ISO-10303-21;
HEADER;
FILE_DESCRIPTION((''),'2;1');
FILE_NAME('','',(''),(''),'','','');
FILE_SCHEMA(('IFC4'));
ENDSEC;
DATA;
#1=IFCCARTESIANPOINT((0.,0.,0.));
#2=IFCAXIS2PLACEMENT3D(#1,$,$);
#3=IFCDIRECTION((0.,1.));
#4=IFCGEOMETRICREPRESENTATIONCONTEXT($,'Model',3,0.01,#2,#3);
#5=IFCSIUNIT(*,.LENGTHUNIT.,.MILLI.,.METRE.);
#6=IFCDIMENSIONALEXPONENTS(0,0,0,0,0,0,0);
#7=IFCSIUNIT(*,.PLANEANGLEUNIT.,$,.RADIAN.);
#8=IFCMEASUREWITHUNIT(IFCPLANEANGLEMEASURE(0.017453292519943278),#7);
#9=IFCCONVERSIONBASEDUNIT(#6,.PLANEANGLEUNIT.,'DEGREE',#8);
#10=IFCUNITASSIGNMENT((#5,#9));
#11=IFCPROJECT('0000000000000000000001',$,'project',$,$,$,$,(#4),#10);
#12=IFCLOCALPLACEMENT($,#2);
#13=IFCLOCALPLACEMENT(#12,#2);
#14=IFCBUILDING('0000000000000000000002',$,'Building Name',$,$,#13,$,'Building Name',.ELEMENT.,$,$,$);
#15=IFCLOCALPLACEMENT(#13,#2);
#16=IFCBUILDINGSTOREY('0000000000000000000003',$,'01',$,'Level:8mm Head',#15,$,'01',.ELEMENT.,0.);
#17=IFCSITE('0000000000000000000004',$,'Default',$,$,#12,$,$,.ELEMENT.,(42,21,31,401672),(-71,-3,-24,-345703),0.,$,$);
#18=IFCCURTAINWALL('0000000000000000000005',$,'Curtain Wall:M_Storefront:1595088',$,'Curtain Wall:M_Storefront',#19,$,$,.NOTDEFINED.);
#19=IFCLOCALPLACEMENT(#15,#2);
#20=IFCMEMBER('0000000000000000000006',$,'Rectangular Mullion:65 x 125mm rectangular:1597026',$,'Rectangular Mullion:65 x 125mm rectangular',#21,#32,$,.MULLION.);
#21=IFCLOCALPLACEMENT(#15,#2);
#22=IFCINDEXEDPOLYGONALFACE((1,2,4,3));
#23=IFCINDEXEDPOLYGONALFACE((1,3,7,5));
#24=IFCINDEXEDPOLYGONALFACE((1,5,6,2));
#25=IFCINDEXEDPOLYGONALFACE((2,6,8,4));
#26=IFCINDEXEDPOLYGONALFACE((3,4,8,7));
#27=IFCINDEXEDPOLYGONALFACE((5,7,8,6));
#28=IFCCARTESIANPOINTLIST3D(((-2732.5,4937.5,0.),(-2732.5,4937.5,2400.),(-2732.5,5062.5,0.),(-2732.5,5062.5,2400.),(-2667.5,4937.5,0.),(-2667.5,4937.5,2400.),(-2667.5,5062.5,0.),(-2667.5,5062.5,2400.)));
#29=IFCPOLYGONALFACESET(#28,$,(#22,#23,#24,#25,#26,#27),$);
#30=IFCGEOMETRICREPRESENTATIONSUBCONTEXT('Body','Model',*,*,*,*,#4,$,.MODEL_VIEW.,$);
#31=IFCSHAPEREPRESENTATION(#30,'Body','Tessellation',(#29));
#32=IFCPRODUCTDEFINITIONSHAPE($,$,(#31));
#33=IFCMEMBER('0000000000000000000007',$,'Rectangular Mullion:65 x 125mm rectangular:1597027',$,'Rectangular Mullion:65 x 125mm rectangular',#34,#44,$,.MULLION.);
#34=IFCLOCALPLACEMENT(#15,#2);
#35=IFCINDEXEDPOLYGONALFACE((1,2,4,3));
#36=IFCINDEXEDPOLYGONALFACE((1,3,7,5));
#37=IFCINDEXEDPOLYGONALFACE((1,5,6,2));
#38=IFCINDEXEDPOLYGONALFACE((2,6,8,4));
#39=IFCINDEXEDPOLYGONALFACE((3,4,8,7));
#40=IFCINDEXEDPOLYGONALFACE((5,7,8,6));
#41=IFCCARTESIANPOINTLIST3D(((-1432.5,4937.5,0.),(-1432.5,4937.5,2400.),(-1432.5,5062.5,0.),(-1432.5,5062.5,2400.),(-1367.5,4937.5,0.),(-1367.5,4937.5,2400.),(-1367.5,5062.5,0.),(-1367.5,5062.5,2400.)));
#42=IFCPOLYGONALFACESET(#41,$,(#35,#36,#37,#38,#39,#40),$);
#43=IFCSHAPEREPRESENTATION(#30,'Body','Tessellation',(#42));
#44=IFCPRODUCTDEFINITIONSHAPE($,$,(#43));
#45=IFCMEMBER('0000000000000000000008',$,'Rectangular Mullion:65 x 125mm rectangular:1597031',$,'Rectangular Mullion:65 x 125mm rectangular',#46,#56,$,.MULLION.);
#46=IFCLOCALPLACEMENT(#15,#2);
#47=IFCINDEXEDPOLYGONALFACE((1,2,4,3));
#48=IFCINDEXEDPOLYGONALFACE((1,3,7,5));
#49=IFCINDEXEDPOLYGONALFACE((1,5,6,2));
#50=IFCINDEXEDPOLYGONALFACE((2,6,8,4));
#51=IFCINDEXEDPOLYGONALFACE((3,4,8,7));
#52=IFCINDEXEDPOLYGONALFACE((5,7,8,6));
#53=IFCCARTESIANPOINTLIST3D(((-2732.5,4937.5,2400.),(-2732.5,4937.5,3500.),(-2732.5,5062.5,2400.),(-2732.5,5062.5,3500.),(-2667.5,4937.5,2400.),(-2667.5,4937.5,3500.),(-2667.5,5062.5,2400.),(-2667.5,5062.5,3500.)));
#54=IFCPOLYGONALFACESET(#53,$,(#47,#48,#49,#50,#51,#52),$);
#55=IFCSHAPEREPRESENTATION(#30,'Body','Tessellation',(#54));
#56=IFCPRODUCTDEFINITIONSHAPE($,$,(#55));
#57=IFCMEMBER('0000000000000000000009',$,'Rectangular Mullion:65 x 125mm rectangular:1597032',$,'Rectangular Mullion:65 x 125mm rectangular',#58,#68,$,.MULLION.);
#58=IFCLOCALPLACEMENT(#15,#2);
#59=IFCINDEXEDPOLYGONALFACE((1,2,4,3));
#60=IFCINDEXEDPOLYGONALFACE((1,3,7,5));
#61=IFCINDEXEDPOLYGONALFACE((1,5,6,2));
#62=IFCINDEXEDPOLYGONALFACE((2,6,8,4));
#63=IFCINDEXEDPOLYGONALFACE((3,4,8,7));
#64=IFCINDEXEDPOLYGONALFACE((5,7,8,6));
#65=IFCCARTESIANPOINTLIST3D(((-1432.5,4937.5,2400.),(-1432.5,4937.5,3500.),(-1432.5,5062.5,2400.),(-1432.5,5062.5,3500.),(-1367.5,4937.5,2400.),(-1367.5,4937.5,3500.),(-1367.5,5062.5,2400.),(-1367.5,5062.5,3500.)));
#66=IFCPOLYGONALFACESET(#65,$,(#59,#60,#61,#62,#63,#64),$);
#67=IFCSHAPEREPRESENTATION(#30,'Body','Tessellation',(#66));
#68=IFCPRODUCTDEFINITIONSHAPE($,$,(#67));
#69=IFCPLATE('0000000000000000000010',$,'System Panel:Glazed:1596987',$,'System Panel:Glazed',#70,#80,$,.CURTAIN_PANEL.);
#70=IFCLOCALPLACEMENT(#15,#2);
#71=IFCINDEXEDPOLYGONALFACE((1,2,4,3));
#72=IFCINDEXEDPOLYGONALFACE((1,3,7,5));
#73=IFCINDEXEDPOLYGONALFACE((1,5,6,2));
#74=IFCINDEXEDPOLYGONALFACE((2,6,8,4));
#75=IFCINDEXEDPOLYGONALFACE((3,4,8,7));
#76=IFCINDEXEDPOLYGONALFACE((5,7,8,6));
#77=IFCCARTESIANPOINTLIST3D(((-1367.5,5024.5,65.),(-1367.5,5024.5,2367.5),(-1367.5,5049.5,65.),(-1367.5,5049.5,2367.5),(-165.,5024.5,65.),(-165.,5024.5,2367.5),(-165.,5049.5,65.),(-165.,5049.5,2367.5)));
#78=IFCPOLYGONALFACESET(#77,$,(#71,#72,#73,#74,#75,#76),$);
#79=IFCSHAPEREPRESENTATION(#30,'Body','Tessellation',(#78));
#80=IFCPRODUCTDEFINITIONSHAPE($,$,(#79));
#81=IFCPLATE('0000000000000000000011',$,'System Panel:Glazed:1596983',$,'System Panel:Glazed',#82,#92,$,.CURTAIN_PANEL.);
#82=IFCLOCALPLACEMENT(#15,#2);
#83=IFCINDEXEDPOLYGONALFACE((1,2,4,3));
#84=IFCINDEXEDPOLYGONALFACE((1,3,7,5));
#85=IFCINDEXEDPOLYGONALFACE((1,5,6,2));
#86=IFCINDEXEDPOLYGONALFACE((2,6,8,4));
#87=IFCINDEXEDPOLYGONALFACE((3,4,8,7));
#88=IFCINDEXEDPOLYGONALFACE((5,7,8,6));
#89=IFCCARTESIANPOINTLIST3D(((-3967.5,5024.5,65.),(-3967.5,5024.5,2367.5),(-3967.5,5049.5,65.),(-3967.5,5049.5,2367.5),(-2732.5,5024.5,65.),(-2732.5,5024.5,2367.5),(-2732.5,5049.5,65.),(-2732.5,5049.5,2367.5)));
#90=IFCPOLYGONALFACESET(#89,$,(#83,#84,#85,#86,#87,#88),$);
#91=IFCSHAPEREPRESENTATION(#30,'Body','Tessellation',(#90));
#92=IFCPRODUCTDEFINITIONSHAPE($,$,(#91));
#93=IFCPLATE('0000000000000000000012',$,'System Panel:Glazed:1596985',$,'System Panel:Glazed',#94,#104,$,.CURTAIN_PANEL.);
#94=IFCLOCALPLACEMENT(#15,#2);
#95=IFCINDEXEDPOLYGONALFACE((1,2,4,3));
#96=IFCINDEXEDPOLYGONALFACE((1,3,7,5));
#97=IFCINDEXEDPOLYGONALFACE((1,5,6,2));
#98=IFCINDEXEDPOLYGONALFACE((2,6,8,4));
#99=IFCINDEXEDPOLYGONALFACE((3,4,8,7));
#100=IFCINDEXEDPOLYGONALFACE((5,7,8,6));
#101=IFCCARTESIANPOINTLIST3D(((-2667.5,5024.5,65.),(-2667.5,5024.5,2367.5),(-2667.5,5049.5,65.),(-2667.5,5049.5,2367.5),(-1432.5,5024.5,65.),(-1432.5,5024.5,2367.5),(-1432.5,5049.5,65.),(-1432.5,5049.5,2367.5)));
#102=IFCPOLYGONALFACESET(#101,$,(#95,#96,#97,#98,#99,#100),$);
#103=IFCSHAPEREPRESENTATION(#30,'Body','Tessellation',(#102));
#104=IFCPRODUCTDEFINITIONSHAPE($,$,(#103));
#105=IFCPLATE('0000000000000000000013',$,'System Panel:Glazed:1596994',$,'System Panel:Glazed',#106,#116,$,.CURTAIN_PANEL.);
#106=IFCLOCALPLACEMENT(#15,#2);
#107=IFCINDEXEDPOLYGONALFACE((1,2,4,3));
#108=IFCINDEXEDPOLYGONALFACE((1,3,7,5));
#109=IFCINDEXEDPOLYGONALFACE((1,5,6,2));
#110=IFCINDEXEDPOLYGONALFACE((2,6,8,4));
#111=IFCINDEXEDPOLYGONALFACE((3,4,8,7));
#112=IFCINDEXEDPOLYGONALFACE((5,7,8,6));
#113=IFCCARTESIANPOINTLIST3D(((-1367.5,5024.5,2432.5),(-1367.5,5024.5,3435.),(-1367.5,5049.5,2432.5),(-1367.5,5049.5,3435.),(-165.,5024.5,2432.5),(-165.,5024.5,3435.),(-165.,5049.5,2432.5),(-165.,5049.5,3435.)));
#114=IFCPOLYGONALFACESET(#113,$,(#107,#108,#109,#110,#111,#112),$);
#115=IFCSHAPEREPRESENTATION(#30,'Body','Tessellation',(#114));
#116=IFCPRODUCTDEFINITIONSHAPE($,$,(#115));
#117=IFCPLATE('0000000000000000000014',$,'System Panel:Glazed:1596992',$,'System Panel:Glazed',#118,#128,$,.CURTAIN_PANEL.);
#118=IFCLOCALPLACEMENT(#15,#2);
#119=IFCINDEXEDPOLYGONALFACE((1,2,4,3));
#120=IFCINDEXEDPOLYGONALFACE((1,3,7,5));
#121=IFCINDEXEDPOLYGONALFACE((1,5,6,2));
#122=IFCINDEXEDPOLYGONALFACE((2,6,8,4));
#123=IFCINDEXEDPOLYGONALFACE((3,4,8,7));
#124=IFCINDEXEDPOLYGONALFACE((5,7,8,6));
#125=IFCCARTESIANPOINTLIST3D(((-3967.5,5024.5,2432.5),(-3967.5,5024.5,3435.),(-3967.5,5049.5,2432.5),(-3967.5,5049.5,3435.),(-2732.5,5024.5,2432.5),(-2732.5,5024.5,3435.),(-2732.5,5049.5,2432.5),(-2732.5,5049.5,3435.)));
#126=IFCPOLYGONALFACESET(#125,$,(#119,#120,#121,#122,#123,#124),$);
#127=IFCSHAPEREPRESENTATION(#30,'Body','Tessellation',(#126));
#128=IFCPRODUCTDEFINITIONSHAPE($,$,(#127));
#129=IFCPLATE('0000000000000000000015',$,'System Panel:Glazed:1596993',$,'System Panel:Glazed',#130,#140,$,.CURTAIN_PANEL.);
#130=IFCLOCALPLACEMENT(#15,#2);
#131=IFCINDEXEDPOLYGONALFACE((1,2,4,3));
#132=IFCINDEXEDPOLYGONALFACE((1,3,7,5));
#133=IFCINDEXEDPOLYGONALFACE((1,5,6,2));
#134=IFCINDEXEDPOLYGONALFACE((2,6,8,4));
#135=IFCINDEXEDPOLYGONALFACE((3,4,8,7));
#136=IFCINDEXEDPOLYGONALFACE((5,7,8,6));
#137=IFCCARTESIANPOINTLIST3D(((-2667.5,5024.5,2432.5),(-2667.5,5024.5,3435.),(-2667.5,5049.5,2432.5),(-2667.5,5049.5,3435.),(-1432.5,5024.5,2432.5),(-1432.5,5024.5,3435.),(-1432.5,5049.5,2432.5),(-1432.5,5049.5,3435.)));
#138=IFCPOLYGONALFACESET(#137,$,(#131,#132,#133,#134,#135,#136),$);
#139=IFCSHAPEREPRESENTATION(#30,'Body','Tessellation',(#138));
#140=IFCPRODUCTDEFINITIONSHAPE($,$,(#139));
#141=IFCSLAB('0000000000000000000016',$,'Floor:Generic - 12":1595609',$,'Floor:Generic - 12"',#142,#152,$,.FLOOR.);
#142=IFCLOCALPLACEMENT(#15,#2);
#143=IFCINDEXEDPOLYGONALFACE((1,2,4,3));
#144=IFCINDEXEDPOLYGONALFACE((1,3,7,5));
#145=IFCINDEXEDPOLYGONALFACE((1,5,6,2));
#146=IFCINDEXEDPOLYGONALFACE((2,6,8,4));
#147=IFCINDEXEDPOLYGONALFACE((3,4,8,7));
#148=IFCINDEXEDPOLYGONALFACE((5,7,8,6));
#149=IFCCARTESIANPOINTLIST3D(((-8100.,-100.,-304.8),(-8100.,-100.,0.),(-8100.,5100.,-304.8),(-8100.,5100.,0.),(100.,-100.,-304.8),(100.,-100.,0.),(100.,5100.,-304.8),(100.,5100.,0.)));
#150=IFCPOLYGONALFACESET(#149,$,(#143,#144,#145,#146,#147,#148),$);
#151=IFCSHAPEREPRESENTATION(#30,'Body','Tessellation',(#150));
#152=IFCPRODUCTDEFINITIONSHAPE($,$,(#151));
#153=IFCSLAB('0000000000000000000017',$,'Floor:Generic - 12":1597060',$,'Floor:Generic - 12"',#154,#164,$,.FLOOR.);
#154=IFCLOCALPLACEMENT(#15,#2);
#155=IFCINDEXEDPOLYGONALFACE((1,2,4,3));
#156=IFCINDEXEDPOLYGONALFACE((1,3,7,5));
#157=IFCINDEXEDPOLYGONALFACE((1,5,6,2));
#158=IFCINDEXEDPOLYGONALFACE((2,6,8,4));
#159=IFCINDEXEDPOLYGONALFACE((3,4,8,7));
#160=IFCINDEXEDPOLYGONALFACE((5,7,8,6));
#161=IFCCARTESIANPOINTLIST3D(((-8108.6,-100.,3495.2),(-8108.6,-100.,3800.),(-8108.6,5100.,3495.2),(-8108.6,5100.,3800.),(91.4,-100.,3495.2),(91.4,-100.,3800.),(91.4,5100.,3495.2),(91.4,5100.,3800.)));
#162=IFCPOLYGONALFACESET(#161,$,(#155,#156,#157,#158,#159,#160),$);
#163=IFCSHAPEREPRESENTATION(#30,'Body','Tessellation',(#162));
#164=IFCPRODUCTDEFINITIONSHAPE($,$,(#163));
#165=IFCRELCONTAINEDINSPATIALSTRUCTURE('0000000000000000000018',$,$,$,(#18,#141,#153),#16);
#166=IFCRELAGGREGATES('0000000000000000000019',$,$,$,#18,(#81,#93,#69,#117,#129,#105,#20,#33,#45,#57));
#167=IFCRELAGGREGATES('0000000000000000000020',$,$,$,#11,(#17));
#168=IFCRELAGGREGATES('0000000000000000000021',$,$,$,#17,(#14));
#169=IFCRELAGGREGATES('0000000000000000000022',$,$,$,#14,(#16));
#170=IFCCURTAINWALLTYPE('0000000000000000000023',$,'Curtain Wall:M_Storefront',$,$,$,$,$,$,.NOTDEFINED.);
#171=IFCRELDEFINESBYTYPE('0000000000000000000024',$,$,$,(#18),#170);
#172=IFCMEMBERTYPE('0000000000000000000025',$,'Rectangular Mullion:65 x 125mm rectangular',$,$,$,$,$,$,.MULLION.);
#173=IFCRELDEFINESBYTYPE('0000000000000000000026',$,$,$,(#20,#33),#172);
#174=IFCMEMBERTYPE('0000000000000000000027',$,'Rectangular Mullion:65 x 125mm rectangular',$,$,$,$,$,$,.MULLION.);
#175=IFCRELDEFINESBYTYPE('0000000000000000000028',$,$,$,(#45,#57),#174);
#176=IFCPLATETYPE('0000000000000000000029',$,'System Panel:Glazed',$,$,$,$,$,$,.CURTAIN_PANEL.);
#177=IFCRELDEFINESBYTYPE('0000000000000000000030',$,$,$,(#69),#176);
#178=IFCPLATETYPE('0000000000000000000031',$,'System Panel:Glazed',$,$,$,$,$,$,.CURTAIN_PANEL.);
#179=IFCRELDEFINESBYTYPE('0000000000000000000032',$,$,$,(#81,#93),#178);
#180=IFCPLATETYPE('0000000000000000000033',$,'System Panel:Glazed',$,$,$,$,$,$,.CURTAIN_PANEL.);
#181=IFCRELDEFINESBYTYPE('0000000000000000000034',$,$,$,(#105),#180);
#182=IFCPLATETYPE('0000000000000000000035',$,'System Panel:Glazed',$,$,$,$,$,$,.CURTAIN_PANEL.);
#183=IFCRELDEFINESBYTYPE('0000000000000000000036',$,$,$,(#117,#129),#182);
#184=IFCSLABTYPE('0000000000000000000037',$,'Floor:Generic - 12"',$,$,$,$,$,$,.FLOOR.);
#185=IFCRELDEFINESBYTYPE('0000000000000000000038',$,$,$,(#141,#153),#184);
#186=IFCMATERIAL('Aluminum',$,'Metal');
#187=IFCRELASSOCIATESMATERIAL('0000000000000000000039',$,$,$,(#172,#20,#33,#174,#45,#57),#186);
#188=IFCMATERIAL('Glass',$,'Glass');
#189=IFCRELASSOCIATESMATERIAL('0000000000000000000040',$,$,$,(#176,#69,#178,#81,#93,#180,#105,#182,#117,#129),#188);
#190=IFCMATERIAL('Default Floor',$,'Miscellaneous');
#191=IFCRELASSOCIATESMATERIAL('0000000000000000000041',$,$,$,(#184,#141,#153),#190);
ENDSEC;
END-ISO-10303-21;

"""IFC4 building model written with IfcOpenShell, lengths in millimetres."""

from ifc_helpers import new_model, entity, si_unit, converted_unit, direction, frame, origin, place, context, subcontext, project, spatial, indexed_curve, outline, extrude, source, transform, mapped, material, type_object, type_shapes, element, aggregate, save


model = new_model("IFC4")

# Units and contexts
model_context = context("Model", 3, precision=0.01, world=origin(), true_north=direction((0.0, 1.0)))
body_context = subcontext(model_context, "Body", "Model", "MODEL_VIEW")
ifc_project = project(units=[si_unit("LENGTHUNIT", "METRE", prefix="MILLI"), converted_unit("PLANEANGLEUNIT", "DEGREE", entity("IfcPlaneAngleMeasure", 0.017453292519943278), si_unit("PLANEANGLEUNIT", "RADIAN"), dimensions=[0, 0, 0, 0, 0, 0, 0])], contexts=[model_context])

# Site, building, storey
site_placement = place(None, origin())
site = spatial("IfcSite", under=ifc_project, at=site_placement, Name="Default", CompositionType="ELEMENT", RefLatitude=(42, 21, 31, 401672), RefLongitude=(-71, -3, -24, -345703), RefElevation=0.0)
building_placement = place(site_placement, origin())
building = spatial("IfcBuilding", under=site, at=building_placement, Name="Building Name", LongName="Building Name", CompositionType="ELEMENT")
storey_placement = place(building_placement, origin())
storey = spatial("IfcBuildingStorey", under=building, at=storey_placement, Name="01", ObjectType="Level:8mm Head", LongName="01", CompositionType="ELEMENT", Elevation=0.0)

# Curtain wall, members, plates
curtain_wall_type = type_object("IfcCurtainWallType", Name="Curtain Wall:M_Storefront", PredefinedType="NOTDEFINED")
curtain_wall_placement = place(storey_placement, origin())
curtain_wall = element("IfcCurtainWall", 1, at=curtain_wall_placement, inside=storey, type_object=curtain_wall_type, Name="Curtain Wall:M_Storefront:1595088", ObjectType="Curtain Wall:M_Storefront", PredefinedType="NOTDEFINED")
ifc_material_1 = material(Name="Aluminum", Category="Metal")
member_type_1 = type_object("IfcMemberType", Name="Rectangular Mullion:65 x 125mm rectangular", PredefinedType="MULLION", material=ifc_material_1)
shared_shape_1 = source(origin(), body_context, "Body", "SweptSolid", [
    extrude(outline(indexed_curve([(-32.5, -62.5), (32.5, -62.5), (32.5, 62.5), (-32.5, 62.5), (-32.5, -62.5)], self_intersect=False)), frame((0.0, 0.0, -2400.0), z_axis=(0.0, 0.0, 1.0), x_axis=(-1.0, 0.0, 0.0)), (0.0, 0.0, 1.0), 2400.0),
])
type_shapes(member_type_1, [shared_shape_1])
member_1_placement = place(curtain_wall_placement, frame((-2700.0, 5000.0, 0.0), z_axis=(0.0, 0.0, -1.0), x_axis=(1.0, 0.0, 0.0)))
member_1 = element("IfcMember", 2, at=member_1_placement, type_object=member_type_1, material=ifc_material_1, Name="Rectangular Mullion:65 x 125mm rectangular:1597026", ObjectType="Rectangular Mullion:65 x 125mm rectangular", PredefinedType="MULLION", context=body_context, shape_type="MappedRepresentation", body=[
    mapped(shared_shape_1, transform((0.0, 0.0, 0.0), scale=1.0)),
])
member_2_placement = place(curtain_wall_placement, frame((-1400.0, 5000.0, 0.0), z_axis=(0.0, 0.0, -1.0), x_axis=(1.0, 0.0, 0.0)))
member_2 = element("IfcMember", 3, at=member_2_placement, type_object=member_type_1, material=ifc_material_1, Name="Rectangular Mullion:65 x 125mm rectangular:1597027", ObjectType="Rectangular Mullion:65 x 125mm rectangular", PredefinedType="MULLION", context=body_context, shape_type="MappedRepresentation", body=[
    mapped(shared_shape_1, transform((0.0, 0.0, 0.0), scale=1.0)),
])
member_type_2 = type_object("IfcMemberType", Name="Rectangular Mullion:65 x 125mm rectangular", PredefinedType="MULLION", material=ifc_material_1)
shared_shape_2 = source(origin(), body_context, "Body", "SweptSolid", [
    extrude(outline(indexed_curve([(-32.5, -62.5), (32.5, -62.5), (32.5, 62.5), (-32.5, 62.5), (-32.5, -62.5)], self_intersect=False)), frame((0.0, 0.0, -1100.0), z_axis=(0.0, 0.0, 1.0), x_axis=(-1.0, 0.0, 0.0)), (0.0, 0.0, 1.0), 1100.0),
])
type_shapes(member_type_2, [shared_shape_2])
member_3_placement = place(curtain_wall_placement, frame((-2700.0, 5000.0, 2400.0), z_axis=(0.0, 0.0, -1.0), x_axis=(1.0, 0.0, 0.0)))
member_3 = element("IfcMember", 4, at=member_3_placement, type_object=member_type_2, material=ifc_material_1, Name="Rectangular Mullion:65 x 125mm rectangular:1597031", ObjectType="Rectangular Mullion:65 x 125mm rectangular", PredefinedType="MULLION", context=body_context, shape_type="MappedRepresentation", body=[
    mapped(shared_shape_2, transform((0.0, 0.0, 0.0), scale=1.0)),
])
member_4_placement = place(curtain_wall_placement, frame((-1400.0, 5000.0, 2400.0), z_axis=(0.0, 0.0, -1.0), x_axis=(1.0, 0.0, 0.0)))
member_4 = element("IfcMember", 5, at=member_4_placement, type_object=member_type_2, material=ifc_material_1, Name="Rectangular Mullion:65 x 125mm rectangular:1597032", ObjectType="Rectangular Mullion:65 x 125mm rectangular", PredefinedType="MULLION", context=body_context, shape_type="MappedRepresentation", body=[
    mapped(shared_shape_2, transform((0.0, 0.0, 0.0), scale=1.0)),
])
ifc_material_2 = material(Name="Glass", Category="Glass")
plate_type_1 = type_object("IfcPlateType", Name="System Panel:Glazed", PredefinedType="CURTAIN_PANEL", material=ifc_material_2)
shared_shape_3 = source(origin(), body_context, "Body", "SweptSolid", [
    extrude(outline(indexed_curve([(-12.5, -601.3), (12.5, -601.3), (12.5, 601.3), (-12.5, 601.3), (-12.5, -601.3)], self_intersect=False)), frame((0.0, 37.0, 0.0), z_axis=(0.0, 0.0, 1.0), x_axis=(0.0, 1.0, 0.0)), (0.0, 0.0, 1.0), 2302.5),
])
type_shapes(plate_type_1, [shared_shape_3])
plate_1_placement = place(curtain_wall_placement, frame((-766.3, 5000.0, 65.0)))
plate_1 = element("IfcPlate", 6, at=plate_1_placement, type_object=plate_type_1, material=ifc_material_2, Name="System Panel:Glazed:1596987", ObjectType="System Panel:Glazed", PredefinedType="CURTAIN_PANEL", context=body_context, shape_type="MappedRepresentation", body=[
    mapped(shared_shape_3, transform((0.0, 0.0, 0.0), scale=1.0)),
])
plate_type_2 = type_object("IfcPlateType", Name="System Panel:Glazed", PredefinedType="CURTAIN_PANEL", material=ifc_material_2)
shared_shape_4 = source(origin(), body_context, "Body", "SweptSolid", [
    extrude(outline(indexed_curve([(-12.5, -617.5), (12.5, -617.5), (12.5, 617.5), (-12.5, 617.5), (-12.5, -617.5)], self_intersect=False)), frame((0.0, 37.0, 0.0), z_axis=(0.0, 0.0, 1.0), x_axis=(0.0, 1.0, 0.0)), (0.0, 0.0, 1.0), 2302.5),
])
type_shapes(plate_type_2, [shared_shape_4])
plate_2_placement = place(curtain_wall_placement, frame((-3350.0, 5000.0, 65.0)))
plate_2 = element("IfcPlate", 7, at=plate_2_placement, type_object=plate_type_2, material=ifc_material_2, Name="System Panel:Glazed:1596983", ObjectType="System Panel:Glazed", PredefinedType="CURTAIN_PANEL", context=body_context, shape_type="MappedRepresentation", body=[
    mapped(shared_shape_4, transform((0.0, 0.0, 0.0), scale=1.0)),
])
plate_3_placement = place(curtain_wall_placement, frame((-2050.0, 5000.0, 65.0)))
plate_3 = element("IfcPlate", 8, at=plate_3_placement, type_object=plate_type_2, material=ifc_material_2, Name="System Panel:Glazed:1596985", ObjectType="System Panel:Glazed", PredefinedType="CURTAIN_PANEL", context=body_context, shape_type="MappedRepresentation", body=[
    mapped(shared_shape_4, transform((0.0, 0.0, 0.0), scale=1.0)),
])
plate_type_3 = type_object("IfcPlateType", Name="System Panel:Glazed", PredefinedType="CURTAIN_PANEL", material=ifc_material_2)
shared_shape_5 = source(origin(), body_context, "Body", "SweptSolid", [
    extrude(outline(indexed_curve([(-12.5, -601.3), (12.5, -601.3), (12.5, 601.3), (-12.5, 601.3), (-12.5, -601.3)], self_intersect=False)), frame((0.0, 37.0, 0.0), z_axis=(0.0, 0.0, 1.0), x_axis=(0.0, 1.0, 0.0)), (0.0, 0.0, 1.0), 1002.5),
])
type_shapes(plate_type_3, [shared_shape_5])
plate_4_placement = place(curtain_wall_placement, frame((-766.3, 5000.0, 2432.5)))
plate_4 = element("IfcPlate", 9, at=plate_4_placement, type_object=plate_type_3, material=ifc_material_2, Name="System Panel:Glazed:1596994", ObjectType="System Panel:Glazed", PredefinedType="CURTAIN_PANEL", context=body_context, shape_type="MappedRepresentation", body=[
    mapped(shared_shape_5, transform((0.0, 0.0, 0.0), scale=1.0)),
])
plate_type_4 = type_object("IfcPlateType", Name="System Panel:Glazed", PredefinedType="CURTAIN_PANEL", material=ifc_material_2)
shared_shape_6 = source(origin(), body_context, "Body", "SweptSolid", [
    extrude(outline(indexed_curve([(-12.5, -617.5), (12.5, -617.5), (12.5, 617.5), (-12.5, 617.5), (-12.5, -617.5)], self_intersect=False)), frame((0.0, 37.0, 0.0), z_axis=(0.0, 0.0, 1.0), x_axis=(0.0, 1.0, 0.0)), (0.0, 0.0, 1.0), 1002.5),
])
type_shapes(plate_type_4, [shared_shape_6])
plate_5_placement = place(curtain_wall_placement, frame((-3350.0, 5000.0, 2432.5)))
plate_5 = element("IfcPlate", 10, at=plate_5_placement, type_object=plate_type_4, material=ifc_material_2, Name="System Panel:Glazed:1596992", ObjectType="System Panel:Glazed", PredefinedType="CURTAIN_PANEL", context=body_context, shape_type="MappedRepresentation", body=[
    mapped(shared_shape_6, transform((0.0, 0.0, 0.0), scale=1.0)),
])
plate_6_placement = place(curtain_wall_placement, frame((-2050.0, 5000.0, 2432.5)))
plate_6 = element("IfcPlate", 11, at=plate_6_placement, type_object=plate_type_4, material=ifc_material_2, Name="System Panel:Glazed:1596993", ObjectType="System Panel:Glazed", PredefinedType="CURTAIN_PANEL", context=body_context, shape_type="MappedRepresentation", body=[
    mapped(shared_shape_6, transform((0.0, 0.0, 0.0), scale=1.0)),
])
aggregate(curtain_wall, [plate_2, plate_3, plate_1, plate_5, plate_6, plate_4, member_1, member_2, member_3, member_4])

# Slabs
ifc_material_3 = material(Name="Default Floor", Category="Miscellaneous")
slab_type = type_object("IfcSlabType", Name="Floor:Generic - 12\"", PredefinedType="FLOOR", material=ifc_material_3)
slab_1_placement = place(storey_placement, origin())
element("IfcSlab", 12, at=slab_1_placement, inside=storey, type_object=slab_type, material=ifc_material_3, Name="Floor:Generic - 12\":1595609", ObjectType="Floor:Generic - 12\"", PredefinedType="FLOOR", context=body_context, shape_type="SweptSolid", body=[
    extrude(outline(indexed_curve([(-2600.0, -4100.0), (2600.0, -4100.0), (2600.0, 4100.0), (-2600.0, 4100.0), (-2600.0, -4100.0)], self_intersect=False)), frame((-4000.0, 2500.0, 0.0), z_axis=(0.0, 0.0, -1.0), x_axis=(0.0, 1.0, 0.0)), (0.0, 0.0, 1.0), 304.8),
])
slab_2_placement = place(storey_placement, origin())
element("IfcSlab", 13, at=slab_2_placement, inside=storey, type_object=slab_type, material=ifc_material_3, Name="Floor:Generic - 12\":1597060", ObjectType="Floor:Generic - 12\"", PredefinedType="FLOOR", context=body_context, shape_type="SweptSolid", body=[
    extrude(outline(indexed_curve([(-2600.0, -4100.0), (2600.0, -4100.0), (2600.0, 4100.0), (-2600.0, 4100.0), (-2600.0, -4100.0)], self_intersect=False)), frame((-4008.6, 2500.0, 3800.0), z_axis=(0.0, 0.0, -1.0), x_axis=(0.0, 1.0, 0.0)), (0.0, 0.0, 1.0), 304.8),
])

save(model, "model.ifc")
